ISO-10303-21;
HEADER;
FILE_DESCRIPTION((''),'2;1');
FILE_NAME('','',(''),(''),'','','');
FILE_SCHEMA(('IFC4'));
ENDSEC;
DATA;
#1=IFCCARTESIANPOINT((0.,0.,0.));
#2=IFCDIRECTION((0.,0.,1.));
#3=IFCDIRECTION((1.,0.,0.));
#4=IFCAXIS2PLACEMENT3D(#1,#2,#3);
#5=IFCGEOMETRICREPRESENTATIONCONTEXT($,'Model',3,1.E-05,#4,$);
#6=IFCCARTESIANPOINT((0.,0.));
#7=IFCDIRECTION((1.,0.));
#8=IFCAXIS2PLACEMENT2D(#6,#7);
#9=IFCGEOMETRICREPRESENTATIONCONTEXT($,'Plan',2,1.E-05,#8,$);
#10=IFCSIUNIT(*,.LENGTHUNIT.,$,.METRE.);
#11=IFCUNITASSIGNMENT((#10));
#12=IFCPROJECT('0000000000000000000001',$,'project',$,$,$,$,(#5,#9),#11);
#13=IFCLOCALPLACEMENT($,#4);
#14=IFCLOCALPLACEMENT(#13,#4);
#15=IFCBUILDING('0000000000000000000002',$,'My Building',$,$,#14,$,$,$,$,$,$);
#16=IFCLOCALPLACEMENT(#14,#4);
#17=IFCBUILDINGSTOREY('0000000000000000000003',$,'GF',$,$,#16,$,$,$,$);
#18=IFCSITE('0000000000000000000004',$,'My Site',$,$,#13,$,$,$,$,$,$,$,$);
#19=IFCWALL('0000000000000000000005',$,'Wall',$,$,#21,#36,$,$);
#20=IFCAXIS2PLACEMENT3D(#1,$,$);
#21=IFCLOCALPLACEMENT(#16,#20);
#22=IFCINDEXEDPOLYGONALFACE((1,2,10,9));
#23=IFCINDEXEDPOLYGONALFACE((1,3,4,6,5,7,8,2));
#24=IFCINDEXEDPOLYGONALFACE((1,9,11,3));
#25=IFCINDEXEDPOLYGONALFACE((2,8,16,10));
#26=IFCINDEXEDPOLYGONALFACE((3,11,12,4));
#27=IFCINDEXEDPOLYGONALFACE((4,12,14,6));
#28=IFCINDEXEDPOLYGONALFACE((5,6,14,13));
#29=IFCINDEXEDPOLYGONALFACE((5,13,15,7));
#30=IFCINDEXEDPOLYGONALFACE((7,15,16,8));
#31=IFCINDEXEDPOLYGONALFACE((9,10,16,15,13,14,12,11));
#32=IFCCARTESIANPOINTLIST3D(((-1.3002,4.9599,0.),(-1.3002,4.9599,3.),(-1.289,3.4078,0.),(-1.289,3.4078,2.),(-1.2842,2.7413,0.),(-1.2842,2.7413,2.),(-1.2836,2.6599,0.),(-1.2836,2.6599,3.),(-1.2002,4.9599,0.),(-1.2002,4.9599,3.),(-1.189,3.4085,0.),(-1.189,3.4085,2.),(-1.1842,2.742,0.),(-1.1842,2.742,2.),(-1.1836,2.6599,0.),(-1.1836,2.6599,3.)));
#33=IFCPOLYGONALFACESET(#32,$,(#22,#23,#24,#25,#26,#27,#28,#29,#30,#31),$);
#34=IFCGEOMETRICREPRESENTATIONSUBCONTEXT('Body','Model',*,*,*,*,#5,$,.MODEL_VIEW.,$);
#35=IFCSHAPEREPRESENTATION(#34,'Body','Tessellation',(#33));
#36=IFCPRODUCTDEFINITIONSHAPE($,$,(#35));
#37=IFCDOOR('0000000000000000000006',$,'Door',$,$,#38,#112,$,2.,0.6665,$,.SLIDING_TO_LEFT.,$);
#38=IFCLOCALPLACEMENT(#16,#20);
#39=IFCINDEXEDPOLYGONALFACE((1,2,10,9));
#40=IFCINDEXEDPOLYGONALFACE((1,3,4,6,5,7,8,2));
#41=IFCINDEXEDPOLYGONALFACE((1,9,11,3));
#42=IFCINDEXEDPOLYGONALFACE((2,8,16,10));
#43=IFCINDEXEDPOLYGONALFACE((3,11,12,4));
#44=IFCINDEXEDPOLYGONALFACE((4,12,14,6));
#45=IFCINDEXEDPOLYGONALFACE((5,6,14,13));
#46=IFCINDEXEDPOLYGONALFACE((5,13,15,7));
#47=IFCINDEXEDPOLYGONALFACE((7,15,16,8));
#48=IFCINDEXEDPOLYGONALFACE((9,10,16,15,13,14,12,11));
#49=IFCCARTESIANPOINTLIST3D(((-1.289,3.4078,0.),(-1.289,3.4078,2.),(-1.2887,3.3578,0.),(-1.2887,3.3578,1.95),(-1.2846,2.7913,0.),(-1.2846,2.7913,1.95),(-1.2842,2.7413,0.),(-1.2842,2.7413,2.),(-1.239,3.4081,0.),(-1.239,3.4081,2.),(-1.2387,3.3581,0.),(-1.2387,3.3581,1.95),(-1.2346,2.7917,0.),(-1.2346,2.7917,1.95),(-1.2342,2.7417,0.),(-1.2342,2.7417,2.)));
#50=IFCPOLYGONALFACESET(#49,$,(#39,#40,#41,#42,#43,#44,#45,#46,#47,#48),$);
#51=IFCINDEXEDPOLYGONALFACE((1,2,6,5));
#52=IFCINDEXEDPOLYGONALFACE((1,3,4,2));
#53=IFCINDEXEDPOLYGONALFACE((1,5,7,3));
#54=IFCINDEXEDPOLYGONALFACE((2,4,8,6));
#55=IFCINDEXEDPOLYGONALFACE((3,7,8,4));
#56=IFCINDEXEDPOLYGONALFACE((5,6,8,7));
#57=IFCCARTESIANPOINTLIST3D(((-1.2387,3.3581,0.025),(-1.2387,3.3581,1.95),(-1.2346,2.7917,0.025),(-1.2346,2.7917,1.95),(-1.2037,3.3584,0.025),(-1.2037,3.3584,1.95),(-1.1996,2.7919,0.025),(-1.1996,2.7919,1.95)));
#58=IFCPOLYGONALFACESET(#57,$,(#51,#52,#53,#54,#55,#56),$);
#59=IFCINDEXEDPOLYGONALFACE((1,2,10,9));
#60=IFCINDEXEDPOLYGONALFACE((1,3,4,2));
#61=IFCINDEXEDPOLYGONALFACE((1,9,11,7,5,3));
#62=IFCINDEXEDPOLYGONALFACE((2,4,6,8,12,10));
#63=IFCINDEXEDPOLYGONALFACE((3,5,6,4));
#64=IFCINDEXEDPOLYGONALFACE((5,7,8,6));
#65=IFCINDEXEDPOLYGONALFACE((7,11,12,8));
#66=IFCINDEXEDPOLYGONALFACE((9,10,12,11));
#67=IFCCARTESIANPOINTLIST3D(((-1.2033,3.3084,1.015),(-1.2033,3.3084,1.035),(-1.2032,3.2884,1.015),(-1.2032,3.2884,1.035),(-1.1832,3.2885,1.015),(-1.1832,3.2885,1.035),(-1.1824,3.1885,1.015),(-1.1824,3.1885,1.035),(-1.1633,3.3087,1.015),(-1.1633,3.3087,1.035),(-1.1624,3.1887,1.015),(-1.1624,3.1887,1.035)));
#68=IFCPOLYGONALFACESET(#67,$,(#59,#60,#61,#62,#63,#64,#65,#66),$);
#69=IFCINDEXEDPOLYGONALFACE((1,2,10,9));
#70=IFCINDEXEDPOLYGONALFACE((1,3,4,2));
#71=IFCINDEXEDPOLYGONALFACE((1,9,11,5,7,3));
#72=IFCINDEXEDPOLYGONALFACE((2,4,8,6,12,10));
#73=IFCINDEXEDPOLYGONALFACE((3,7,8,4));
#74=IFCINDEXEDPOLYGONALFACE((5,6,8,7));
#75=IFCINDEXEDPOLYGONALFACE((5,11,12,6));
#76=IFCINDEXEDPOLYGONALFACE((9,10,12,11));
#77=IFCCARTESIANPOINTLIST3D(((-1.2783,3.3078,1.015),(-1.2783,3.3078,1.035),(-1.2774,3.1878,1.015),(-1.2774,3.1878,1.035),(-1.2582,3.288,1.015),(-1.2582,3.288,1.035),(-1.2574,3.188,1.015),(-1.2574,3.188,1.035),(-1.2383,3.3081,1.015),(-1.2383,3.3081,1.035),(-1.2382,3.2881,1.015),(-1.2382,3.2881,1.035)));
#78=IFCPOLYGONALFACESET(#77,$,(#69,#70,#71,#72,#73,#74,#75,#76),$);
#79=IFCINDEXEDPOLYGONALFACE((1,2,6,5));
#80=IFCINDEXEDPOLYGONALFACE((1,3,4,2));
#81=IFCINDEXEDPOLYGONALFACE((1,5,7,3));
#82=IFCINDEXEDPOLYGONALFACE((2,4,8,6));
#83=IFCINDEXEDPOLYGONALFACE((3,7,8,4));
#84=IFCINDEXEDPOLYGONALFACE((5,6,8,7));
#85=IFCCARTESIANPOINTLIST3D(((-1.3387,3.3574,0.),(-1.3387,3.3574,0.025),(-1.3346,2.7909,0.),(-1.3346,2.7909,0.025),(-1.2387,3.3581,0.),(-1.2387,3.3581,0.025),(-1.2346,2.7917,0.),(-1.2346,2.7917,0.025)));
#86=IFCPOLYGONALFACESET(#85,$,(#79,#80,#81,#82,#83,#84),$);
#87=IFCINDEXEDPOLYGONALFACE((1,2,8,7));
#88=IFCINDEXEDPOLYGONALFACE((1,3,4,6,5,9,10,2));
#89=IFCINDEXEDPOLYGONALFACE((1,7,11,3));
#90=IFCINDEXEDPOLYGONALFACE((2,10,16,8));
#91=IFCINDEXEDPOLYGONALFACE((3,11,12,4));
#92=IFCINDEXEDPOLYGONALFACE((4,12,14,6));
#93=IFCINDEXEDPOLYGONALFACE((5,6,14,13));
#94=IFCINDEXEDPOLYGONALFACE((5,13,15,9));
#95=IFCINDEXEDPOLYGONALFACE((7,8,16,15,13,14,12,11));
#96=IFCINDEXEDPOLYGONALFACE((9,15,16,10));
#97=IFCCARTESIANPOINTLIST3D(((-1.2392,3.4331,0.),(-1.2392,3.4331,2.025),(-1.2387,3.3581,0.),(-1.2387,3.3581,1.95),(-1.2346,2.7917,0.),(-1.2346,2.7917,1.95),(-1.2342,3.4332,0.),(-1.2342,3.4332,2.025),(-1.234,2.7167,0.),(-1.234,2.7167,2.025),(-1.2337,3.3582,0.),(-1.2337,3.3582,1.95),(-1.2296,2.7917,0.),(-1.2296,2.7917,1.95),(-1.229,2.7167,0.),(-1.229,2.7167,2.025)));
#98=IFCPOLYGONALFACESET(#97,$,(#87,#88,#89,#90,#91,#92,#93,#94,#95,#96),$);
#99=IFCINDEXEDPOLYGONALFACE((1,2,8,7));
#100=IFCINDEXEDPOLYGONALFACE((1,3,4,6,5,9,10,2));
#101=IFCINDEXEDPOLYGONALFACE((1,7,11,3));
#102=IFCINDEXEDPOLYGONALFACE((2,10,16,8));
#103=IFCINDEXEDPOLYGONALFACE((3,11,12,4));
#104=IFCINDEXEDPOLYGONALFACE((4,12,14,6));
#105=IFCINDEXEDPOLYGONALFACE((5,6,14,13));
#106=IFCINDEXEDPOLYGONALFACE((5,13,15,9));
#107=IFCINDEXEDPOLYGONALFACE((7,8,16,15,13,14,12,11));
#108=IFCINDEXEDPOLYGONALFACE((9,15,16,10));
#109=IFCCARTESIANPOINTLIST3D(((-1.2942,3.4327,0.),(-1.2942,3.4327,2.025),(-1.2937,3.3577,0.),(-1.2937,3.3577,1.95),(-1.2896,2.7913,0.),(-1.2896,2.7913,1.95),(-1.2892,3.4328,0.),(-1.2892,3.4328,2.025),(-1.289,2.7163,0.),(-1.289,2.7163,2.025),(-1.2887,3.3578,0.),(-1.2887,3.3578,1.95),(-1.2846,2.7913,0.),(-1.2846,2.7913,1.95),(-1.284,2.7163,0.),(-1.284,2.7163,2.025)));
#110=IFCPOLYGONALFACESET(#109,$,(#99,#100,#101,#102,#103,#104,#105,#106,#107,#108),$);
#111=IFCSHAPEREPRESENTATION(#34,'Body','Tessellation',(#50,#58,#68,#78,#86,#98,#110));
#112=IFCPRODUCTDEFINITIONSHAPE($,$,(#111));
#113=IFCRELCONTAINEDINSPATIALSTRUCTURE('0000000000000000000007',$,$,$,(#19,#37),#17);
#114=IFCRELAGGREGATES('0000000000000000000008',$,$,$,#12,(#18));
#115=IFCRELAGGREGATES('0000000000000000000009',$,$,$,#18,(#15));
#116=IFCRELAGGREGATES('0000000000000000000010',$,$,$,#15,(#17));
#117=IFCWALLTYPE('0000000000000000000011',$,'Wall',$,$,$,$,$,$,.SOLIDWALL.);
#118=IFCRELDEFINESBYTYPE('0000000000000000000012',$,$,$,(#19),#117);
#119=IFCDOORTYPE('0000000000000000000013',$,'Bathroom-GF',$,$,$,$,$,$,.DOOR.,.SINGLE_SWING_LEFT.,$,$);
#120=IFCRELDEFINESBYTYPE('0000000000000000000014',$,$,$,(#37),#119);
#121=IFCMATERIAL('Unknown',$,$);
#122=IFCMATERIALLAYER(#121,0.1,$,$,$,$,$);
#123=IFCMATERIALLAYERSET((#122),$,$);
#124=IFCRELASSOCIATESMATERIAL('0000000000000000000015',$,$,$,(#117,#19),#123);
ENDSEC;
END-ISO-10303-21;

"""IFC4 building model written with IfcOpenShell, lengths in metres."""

from ifc_helpers import new_model, entity, si_unit, frame, origin_with_axes, origin_2d_with_axis, place, context, subcontext, project, spatial, line, indexed_curve, outline, extrude, shape, source, transform, mapped, material, layer, layer_set, layer_usage, type_object, type_shapes, element, fill, save


model = new_model("IFC4")

# Units and contexts
model_context = context("Model", 3, precision=1e-05, world=origin_with_axes())
plan_context = context("Plan", 2, precision=1e-05, world=origin_2d_with_axis())
body_context_1 = subcontext(model_context, "Body", "Model", "MODEL_VIEW")
body_context_2 = subcontext(plan_context, "Body", "Plan", "PLAN_VIEW")
ifc_project = project(units=[si_unit("LENGTHUNIT", "METRE")], contexts=[model_context, plan_context])

# Site, building, storey
site_placement = place(None, origin_with_axes())
site = spatial("IfcSite", under=ifc_project, at=site_placement, Name="My Site")
building_placement = place(site_placement, origin_with_axes())
building = spatial("IfcBuilding", under=site, at=building_placement, Name="My Building")
storey_placement = place(building_placement, origin_with_axes())
storey = spatial("IfcBuildingStorey", under=building, at=storey_placement, Name="GF")

# Shared definitions
ifc_material = material(Name="Unknown")
ifc_layer = layer(ifc_material, 0.1)
ifc_layer_set = layer_set([ifc_layer])
wall_type = type_object("IfcWallType", Name="Wall", PredefinedType="SOLIDWALL", material=ifc_layer_set)

# Wall, opening, door
ifc_layer_usage_1 = layer_usage(ifc_layer_set, "AXIS2", "POSITIVE", 0.0)
wall_1_placement = place(storey_placement, frame((-1.3009, 5.0599, 0.0), z_axis=(0.0, 0.0, 1.0), x_axis=(0.007195, -0.999974, 0.0)))
wall_1 = element("IfcWall", 1, at=wall_1_placement, inside=storey, type_object=wall_type, material=ifc_layer_usage_1, Name="Wall", context=body_context_1, shape_type="SweptSolid", body=[
    extrude(outline(indexed_curve([(0.1, 0.0), (0.1007, 0.1), (2.4008, 0.1), (2.4001, 0.0)], segments=[line(1, 2, 3, 4, 1)])), origin_with_axes(), (0.0, 0.0, 1.0), 3.0),
])
shared_shape_1 = source(origin_with_axes(), body_context_1, "Body", "SweptSolid", [
    extrude(outline(indexed_curve([(0.0, 0.0), (0.6665, 0.0), (0.6665, 2.0), (0.0, 2.0)], segments=[line(1, 2, 3, 4, 1)])), frame((0.0, -0.6, 0.0), z_axis=(0.0, -1.0, 0.0), x_axis=(1.0, 0.0, 0.0)), (0.0, 0.0, -1.0), 1.2),
])
opening_1_placement = place(wall_1_placement, frame((2.3187, 0.05, 0.0), z_axis=(0.0, 0.0, 1.0), x_axis=(-1.0, 0.000001, 0.0)))
opening_1 = element("IfcOpeningElement", 2, at=opening_1_placement, cuts=wall_1, PredefinedType="OPENING", context=body_context_1, shape_type="MappedRepresentation", body=[
    mapped(shared_shape_1, transform((0.0, 0.0, 0.0), x_axis=(1.0, 0.0, 0.0), y_axis=(0.0, 1.0, 0.0), z_axis=(0.0, 0.0, 1.0), scale=1.0)),
])
door_type_1 = type_object("IfcDoorType", Name="Bathroom-GF", OperationType="SINGLE_SWING_LEFT", PredefinedType="DOOR")
shared_shape_2 = source(origin_with_axes(), body_context_1, "Body", "SweptSolid", [
    extrude(outline(indexed_curve([(0.0, 0.0), (0.0, 2.0), (0.6665, 2.0), (0.6665, 0.0), (0.6165, 0.0), (0.6165, 1.95), (0.05, 1.95), (0.05, 0.0)], segments=[line(1, 2, 3, 4, 5, 6, 7, 8, 1)])), frame((0.0, 0.0, 0.0), z_axis=(0.0, -1.0, 0.0), x_axis=(1.0, 0.0, 0.0)), (0.0, 0.0, -1.0), 0.05),
    extrude(outline(indexed_curve([(0.0, 0.0), (0.5665, 0.0), (0.5665, 0.035), (0.0, 0.035)], segments=[line(1, 2, 3, 4, 1)])), frame((0.05, -0.035, 0.025), z_axis=(0.0, 0.0, 1.0), x_axis=(1.0, 0.0, 0.0)), (0.0, 0.0, 1.0), 1.925),
    extrude(outline(indexed_curve([(0.0, 0.0), (0.0, -0.04), (-0.12, -0.04), (-0.12, -0.02), (-0.02, -0.02), (-0.02, 0.0)], segments=[line(1, 2, 3, 4, 5, 6, 1)])), frame((0.5665, -0.035, 1.015), z_axis=(0.0, 0.0, 1.0), x_axis=(1.0, 0.0, 0.0)), (0.0, 0.0, 1.0), 0.02),
    extrude(outline(indexed_curve([(0.0, 0.0), (0.0, 0.04), (-0.12, 0.04), (-0.12, 0.02), (-0.02, 0.02), (-0.02, 0.0)], segments=[line(1, 2, 3, 4, 5, 6, 1)])), frame((0.5665, 0.0, 1.015), z_axis=(0.0, 0.0, 1.0), x_axis=(1.0, 0.0, 0.0)), (0.0, 0.0, 1.0), 0.02),
    extrude(outline(indexed_curve([(0.0, 0.0), (0.5665, 0.0), (0.5665, 0.1), (0.0, 0.1)], segments=[line(1, 2, 3, 4, 1)])), frame((0.05, 0.0, 0.0), z_axis=(0.0, 0.0, 1.0), x_axis=(1.0, 0.0, 0.0)), (0.0, 0.0, 1.0), 0.025),
    extrude(outline(indexed_curve([(0.0, 0.0), (0.0, 2.025), (0.7165, 2.025), (0.7165, 0.0), (0.6415, 0.0), (0.6415, 1.95), (0.075, 1.95), (0.075, 0.0)], segments=[line(1, 2, 3, 4, 5, 6, 7, 8, 1)])), frame((-0.025, -0.005, 0.0), z_axis=(0.0, -1.0, 0.0), x_axis=(1.0, 0.0, 0.0)), (0.0, 0.0, -1.0), 0.005),
    extrude(outline(indexed_curve([(0.0, 0.0), (0.0, 2.025), (0.7165, 2.025), (0.7165, 0.0), (0.6415, 0.0), (0.6415, 1.95), (0.075, 1.95), (0.075, 0.0)], segments=[line(1, 2, 3, 4, 5, 6, 7, 8, 1)])), frame((-0.025, 0.05, 0.0), z_axis=(0.0, -1.0, 0.0), x_axis=(1.0, 0.0, 0.0)), (0.0, 0.0, -1.0), 0.005),
])
shared_shape_3 = source(origin_with_axes(), body_context_2, "Body", "Curve2D", [
    entity("IfcIndexedPolyCurve", entity("IfcCartesianPointList2D", [[0.0, 0.0], [0.05, 0.0], [0.05, 0.05], [0.0, 0.05]]), [entity("IfcLineIndex", [1, 2, 3, 4, 1])]),
    entity("IfcIndexedPolyCurve", entity("IfcCartesianPointList2D", [[0.6665, 0.0], [0.6165, 0.0], [0.6165, 0.05], [0.6665, 0.05]]), [entity("IfcLineIndex", [1, 2, 3, 4, 1])]),
    entity("IfcIndexedPolyCurve", entity("IfcCartesianPointList2D", [[-0.2332, -0.035], [0.3332, -0.035], [0.3332, 0.0], [-0.2332, 0.0]]), [entity("IfcLineIndex", [1, 2, 3, 4, 1])]),
])
type_shapes(door_type_1, [shared_shape_2, shared_shape_3])
door_1_placement = place(opening_1_placement, frame((0.0, 0.0, 0.0), z_axis=(0.0, 0.0, 1.0), x_axis=(1.0, 0.0, 0.0)))
door_1 = element("IfcDoor", 3, at=door_1_placement, inside=storey, type_object=door_type_1, Name="Door", OperationType="SLIDING_TO_LEFT", OverallHeight=2.0, OverallWidth=0.6665, shapes=[
    shape(body_context_1, "Body", "MappedRepresentation", [mapped(shared_shape_2, transform((0.0, 0.0, 0.0), x_axis=(1.0, 0.0, 0.0), y_axis=(0.0, 1.0, 0.0), z_axis=(0.0, 0.0, 1.0), scale=1.0))]),
    shape(body_context_2, "Body", "MappedRepresentation", [mapped(shared_shape_3, transform((0.0, 0.0, 0.0), x_axis=(1.0, 0.0, 0.0), y_axis=(0.0, 1.0, 0.0), z_axis=(0.0, 0.0, 1.0), scale=1.0))]),
])
fill(opening_1, door_1)

save(model, "model.ifc")
